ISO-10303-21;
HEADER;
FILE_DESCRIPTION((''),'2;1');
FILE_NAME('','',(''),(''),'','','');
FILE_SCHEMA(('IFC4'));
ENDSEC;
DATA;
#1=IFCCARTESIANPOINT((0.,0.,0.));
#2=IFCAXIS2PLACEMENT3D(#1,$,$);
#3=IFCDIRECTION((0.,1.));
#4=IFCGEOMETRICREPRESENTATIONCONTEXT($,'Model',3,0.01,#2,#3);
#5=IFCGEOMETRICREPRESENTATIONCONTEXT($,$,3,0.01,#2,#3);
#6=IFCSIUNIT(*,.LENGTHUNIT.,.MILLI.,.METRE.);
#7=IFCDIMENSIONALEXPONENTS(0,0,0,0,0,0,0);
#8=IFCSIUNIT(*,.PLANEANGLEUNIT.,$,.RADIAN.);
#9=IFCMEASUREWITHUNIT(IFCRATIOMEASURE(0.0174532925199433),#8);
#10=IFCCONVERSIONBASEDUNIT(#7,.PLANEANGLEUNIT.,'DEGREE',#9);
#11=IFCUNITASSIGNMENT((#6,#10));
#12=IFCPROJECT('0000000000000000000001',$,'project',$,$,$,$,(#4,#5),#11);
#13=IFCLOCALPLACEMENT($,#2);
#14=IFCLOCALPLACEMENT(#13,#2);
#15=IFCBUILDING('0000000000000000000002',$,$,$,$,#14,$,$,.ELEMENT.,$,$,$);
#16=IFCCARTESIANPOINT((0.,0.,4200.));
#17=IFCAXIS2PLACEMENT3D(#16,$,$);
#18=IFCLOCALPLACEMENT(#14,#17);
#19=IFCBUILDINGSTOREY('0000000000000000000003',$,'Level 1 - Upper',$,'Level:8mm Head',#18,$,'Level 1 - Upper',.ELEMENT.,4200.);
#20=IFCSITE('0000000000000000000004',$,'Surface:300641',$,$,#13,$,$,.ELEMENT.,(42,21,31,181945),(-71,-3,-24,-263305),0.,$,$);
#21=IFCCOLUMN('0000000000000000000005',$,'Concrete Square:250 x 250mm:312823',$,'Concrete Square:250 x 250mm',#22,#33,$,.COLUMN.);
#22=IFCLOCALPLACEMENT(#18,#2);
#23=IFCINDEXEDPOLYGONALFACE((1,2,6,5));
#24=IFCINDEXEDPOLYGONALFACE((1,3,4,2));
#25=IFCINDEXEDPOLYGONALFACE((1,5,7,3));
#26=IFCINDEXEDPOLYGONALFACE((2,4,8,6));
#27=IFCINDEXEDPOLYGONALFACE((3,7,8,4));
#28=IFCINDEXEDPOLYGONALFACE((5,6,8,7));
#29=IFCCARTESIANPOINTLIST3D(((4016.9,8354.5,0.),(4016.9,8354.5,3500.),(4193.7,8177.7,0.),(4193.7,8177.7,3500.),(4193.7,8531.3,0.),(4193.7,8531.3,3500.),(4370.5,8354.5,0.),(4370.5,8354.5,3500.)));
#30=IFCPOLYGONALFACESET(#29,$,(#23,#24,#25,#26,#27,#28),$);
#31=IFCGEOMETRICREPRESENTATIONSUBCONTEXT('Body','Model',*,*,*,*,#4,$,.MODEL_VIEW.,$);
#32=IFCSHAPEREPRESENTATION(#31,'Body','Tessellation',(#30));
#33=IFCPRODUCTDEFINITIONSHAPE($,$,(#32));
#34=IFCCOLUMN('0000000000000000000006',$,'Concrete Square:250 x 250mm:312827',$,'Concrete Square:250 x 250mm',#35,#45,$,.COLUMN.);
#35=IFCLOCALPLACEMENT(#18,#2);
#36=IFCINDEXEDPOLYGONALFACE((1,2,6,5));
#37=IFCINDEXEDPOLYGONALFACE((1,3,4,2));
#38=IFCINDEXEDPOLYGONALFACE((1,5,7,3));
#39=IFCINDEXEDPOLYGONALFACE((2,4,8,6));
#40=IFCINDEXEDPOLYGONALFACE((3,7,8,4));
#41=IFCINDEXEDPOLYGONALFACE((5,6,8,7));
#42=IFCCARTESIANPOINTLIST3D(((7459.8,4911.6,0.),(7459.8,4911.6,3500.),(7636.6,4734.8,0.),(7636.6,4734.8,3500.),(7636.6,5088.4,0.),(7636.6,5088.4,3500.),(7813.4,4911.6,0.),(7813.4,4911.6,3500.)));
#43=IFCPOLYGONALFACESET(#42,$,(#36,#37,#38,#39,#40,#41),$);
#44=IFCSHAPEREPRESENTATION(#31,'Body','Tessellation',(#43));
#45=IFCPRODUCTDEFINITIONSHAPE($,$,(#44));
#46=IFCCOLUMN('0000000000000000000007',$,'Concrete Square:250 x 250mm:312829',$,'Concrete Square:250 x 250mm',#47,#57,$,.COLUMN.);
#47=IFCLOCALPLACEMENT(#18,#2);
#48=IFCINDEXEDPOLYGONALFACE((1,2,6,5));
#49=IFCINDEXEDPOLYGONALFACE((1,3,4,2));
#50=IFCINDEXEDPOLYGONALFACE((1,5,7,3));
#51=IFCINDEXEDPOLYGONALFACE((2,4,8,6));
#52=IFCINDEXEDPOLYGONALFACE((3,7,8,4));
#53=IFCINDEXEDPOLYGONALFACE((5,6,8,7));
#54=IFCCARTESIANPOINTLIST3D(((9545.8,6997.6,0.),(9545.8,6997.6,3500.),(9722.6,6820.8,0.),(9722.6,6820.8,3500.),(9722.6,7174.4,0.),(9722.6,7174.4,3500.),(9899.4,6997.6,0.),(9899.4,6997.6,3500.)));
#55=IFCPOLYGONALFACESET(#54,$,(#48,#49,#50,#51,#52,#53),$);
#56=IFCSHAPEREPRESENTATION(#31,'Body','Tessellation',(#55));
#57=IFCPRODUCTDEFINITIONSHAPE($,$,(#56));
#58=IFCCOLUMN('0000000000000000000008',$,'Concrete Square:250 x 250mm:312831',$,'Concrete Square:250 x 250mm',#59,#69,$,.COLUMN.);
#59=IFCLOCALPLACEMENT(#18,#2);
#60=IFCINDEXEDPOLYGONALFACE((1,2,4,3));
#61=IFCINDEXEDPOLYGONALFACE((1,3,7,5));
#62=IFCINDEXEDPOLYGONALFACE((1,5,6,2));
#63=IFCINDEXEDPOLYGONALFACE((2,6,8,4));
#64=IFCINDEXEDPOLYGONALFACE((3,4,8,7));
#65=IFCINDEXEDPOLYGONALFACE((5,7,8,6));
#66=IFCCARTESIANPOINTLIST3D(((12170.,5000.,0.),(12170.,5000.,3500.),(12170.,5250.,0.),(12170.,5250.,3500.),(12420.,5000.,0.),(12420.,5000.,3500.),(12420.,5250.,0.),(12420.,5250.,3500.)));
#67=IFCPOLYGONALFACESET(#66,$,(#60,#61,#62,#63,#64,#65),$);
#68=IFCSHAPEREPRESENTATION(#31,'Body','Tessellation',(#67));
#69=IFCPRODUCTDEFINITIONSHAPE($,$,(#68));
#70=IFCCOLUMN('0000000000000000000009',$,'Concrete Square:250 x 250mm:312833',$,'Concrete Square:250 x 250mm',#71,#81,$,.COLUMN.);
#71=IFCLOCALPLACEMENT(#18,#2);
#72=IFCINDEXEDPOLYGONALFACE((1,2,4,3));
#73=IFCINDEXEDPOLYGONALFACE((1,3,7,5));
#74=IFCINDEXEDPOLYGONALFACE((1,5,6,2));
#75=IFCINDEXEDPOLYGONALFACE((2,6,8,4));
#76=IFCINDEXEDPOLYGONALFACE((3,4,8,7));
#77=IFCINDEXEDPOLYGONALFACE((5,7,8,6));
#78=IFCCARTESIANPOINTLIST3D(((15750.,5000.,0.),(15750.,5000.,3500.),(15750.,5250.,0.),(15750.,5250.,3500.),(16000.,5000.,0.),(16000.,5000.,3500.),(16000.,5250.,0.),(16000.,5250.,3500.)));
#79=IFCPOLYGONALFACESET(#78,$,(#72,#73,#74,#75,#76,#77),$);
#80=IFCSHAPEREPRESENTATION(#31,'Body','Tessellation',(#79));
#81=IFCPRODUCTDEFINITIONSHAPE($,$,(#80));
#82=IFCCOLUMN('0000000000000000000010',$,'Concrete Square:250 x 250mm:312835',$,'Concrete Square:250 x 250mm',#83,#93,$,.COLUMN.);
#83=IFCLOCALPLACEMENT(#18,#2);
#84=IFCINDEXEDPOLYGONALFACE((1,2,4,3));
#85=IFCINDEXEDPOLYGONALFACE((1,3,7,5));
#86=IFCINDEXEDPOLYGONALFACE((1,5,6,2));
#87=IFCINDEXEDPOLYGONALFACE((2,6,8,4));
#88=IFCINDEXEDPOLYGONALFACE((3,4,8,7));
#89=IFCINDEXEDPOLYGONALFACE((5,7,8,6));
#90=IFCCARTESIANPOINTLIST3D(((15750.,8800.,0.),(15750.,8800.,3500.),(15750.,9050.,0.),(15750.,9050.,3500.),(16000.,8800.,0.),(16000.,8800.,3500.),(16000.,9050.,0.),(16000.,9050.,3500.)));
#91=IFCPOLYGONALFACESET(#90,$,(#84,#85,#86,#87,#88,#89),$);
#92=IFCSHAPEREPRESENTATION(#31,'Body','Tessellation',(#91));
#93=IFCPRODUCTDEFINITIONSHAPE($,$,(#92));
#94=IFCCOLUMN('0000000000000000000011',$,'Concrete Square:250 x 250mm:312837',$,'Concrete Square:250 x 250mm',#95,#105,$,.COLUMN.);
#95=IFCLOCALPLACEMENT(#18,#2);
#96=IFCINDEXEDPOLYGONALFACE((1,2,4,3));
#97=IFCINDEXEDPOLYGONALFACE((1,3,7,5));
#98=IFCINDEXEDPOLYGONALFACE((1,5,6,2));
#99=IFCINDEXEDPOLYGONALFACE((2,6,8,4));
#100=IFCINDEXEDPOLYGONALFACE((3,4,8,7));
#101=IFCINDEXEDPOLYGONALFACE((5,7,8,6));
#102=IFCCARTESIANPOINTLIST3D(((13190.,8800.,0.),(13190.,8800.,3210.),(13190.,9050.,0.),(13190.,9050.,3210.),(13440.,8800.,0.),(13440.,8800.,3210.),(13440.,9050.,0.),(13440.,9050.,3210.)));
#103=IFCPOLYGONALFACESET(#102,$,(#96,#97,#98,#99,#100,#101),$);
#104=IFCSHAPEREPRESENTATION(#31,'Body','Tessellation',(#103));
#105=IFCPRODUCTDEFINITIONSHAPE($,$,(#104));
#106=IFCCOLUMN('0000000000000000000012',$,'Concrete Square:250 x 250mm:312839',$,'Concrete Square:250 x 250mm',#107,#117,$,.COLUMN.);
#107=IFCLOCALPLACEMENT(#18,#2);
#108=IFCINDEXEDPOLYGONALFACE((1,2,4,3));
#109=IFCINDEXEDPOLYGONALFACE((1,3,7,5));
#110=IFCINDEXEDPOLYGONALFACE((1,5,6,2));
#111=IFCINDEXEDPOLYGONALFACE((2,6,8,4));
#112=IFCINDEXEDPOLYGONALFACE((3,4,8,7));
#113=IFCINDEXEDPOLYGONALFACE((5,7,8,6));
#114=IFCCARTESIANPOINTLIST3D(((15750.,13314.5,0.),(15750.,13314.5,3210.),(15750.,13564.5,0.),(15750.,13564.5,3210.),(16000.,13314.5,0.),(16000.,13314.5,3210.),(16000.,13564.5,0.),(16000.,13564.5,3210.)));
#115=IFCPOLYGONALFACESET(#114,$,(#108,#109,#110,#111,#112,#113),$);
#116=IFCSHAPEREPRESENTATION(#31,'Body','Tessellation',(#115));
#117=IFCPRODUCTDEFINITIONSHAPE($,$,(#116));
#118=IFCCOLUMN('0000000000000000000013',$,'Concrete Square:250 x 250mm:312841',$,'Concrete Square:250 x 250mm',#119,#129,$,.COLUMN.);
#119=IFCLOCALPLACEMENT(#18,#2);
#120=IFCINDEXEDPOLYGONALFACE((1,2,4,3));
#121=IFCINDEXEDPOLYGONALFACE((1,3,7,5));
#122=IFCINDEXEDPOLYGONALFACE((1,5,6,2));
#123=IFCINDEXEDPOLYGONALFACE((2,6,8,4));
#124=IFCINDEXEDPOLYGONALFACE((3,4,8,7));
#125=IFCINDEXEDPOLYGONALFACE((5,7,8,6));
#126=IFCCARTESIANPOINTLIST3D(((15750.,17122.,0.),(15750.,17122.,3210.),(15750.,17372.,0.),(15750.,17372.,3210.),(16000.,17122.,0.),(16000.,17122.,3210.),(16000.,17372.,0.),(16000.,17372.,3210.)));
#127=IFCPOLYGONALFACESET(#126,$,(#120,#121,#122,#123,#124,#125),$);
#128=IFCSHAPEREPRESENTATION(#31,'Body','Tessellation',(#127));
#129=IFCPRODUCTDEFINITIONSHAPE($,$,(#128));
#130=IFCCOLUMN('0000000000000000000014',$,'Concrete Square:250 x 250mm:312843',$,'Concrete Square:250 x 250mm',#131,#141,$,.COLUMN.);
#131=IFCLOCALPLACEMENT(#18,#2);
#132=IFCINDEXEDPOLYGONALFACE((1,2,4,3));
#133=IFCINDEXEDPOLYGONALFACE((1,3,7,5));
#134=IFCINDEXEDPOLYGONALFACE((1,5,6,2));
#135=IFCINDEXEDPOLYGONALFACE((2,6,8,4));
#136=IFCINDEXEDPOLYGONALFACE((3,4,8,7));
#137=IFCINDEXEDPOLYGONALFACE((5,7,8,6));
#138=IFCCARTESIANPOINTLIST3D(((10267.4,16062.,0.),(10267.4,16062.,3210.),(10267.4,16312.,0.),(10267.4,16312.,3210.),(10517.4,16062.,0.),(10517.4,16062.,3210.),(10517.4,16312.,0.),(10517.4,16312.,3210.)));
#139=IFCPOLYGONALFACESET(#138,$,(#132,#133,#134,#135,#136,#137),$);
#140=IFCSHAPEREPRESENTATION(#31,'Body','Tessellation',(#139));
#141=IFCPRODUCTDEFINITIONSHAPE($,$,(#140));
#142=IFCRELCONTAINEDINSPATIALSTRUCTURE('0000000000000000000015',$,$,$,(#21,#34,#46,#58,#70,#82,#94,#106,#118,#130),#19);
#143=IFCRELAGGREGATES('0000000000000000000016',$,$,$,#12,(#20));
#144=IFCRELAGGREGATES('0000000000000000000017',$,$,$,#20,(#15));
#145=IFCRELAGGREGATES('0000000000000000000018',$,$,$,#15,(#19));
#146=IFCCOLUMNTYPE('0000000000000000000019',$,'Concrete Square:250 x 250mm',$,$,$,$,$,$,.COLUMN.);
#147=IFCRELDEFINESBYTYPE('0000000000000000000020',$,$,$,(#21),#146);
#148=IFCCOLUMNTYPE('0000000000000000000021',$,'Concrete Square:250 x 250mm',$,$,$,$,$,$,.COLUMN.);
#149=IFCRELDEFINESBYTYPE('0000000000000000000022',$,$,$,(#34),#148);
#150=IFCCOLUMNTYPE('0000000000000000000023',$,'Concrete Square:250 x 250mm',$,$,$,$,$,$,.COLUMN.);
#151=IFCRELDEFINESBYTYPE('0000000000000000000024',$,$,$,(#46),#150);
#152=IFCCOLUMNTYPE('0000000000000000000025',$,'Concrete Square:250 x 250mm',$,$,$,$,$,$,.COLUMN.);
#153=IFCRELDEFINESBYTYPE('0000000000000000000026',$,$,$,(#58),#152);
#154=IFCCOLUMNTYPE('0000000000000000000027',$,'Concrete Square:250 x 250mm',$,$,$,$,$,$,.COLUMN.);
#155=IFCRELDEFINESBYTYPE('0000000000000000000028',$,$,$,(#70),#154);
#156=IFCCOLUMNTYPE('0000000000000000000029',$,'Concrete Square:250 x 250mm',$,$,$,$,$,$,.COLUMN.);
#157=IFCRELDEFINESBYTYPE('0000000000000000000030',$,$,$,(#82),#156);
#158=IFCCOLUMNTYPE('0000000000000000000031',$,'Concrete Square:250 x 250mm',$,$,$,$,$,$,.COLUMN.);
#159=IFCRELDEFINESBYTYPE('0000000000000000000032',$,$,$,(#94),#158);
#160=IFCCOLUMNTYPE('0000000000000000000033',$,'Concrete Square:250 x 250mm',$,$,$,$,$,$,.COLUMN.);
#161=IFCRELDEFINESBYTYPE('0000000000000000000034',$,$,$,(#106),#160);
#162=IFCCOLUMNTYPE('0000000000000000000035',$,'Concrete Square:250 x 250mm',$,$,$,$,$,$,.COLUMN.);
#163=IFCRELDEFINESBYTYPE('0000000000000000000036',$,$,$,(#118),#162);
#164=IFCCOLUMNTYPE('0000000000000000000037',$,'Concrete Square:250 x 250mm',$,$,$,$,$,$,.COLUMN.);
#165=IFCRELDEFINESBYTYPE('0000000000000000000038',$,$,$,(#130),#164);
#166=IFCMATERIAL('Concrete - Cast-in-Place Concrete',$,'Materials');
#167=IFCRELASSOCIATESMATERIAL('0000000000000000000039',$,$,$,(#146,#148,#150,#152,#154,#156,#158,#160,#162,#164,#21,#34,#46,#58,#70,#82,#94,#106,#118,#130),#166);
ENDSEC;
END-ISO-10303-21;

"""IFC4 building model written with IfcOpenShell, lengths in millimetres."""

from ifc_helpers import new_model, entity, si_unit, converted_unit, direction, frame, frame_2d, origin, origin_2d_with_axis, place, context, subcontext, project, spatial, rectangle, extrude, source, transform, mapped, material, material_profile, profile_set, profile_usage, type_object, type_shapes, element, save


model = new_model("IFC4")

# Units and contexts
model_context = context("Model", 3, precision=0.01, world=origin(), true_north=direction((0.0, 1.0)))
context_of_model = context(None, 3, precision=0.01, world=origin(), true_north=direction((0.0, 1.0)))
body_context = subcontext(model_context, "Body", "Model", "MODEL_VIEW")
ifc_project = project(units=[si_unit("LENGTHUNIT", "METRE", prefix="MILLI"), converted_unit("PLANEANGLEUNIT", "DEGREE", entity("IfcRatioMeasure", 0.0174532925199433), si_unit("PLANEANGLEUNIT", "RADIAN"), dimensions=[0, 0, 0, 0, 0, 0, 0])], contexts=[model_context, context_of_model])

# Site, building, storey
site_placement = place(None, origin())
site = spatial("IfcSite", under=ifc_project, at=site_placement, Name="Surface:300641", CompositionType="ELEMENT", RefLatitude=(42, 21, 31, 181945), RefLongitude=(-71, -3, -24, -263305), RefElevation=0.0)
building_placement = place(site_placement, origin())
building = spatial("IfcBuilding", under=site, at=building_placement, CompositionType="ELEMENT")
storey_placement = place(building_placement, frame((0.0, 0.0, 4200.0)))
storey = spatial("IfcBuildingStorey", under=building, at=storey_placement, Name="Level 1 - Upper", ObjectType="Level:8mm Head", LongName="Level 1 - Upper", CompositionType="ELEMENT", Elevation=4200.0)

# Columns
ifc_material = material(Name="Concrete - Cast-in-Place Concrete", Category="Materials")
ifc_material_profile_1 = material_profile(ifc_material, rectangle(XDim=250.0, YDim=250.0, at=frame_2d((0.0, 0.0), x_axis=(1.0, 0.0))), Name="250 x 250mm")
ifc_profile_set_1 = profile_set([ifc_material_profile_1], Name="250 x 250mm")
ifc_profile_usage_1 = profile_usage(ifc_profile_set_1)
column_type_1 = type_object("IfcColumnType", Name="Concrete Square:250 x 250mm", PredefinedType="COLUMN", material=ifc_profile_set_1)
shared_shape_1 = source(origin(), body_context, "Body", "SweptSolid", [
    extrude(rectangle(XDim=250.0, YDim=250.0, at=frame_2d((0.0, 0.0), x_axis=(1.0, 0.0))), frame((4193.7, 8354.5, 4200.0), z_axis=(0.0, 0.0, 1.0), x_axis=(-0.707107, 0.707107, 0.0)), (0.0, 0.0, 1.0), 3500.0),
])
type_shapes(column_type_1, [shared_shape_1])
column_1_placement = place(storey_placement, frame((0.0, 0.0, -4200.0)))
element("IfcColumn", 1, at=column_1_placement, inside=storey, type_object=column_type_1, material=ifc_profile_usage_1, Name="Concrete Square:250 x 250mm:312823", ObjectType="Concrete Square:250 x 250mm", PredefinedType="COLUMN", context=body_context, shape_type="MappedRepresentation", body=[
    mapped(shared_shape_1, transform((0.0, 0.0, 0.0), scale=1.0)),
])
ifc_profile_usage_2 = profile_usage(ifc_profile_set_1)
column_type_2 = type_object("IfcColumnType", Name="Concrete Square:250 x 250mm", PredefinedType="COLUMN", material=ifc_profile_set_1)
shared_shape_2 = source(origin(), body_context, "Body", "SweptSolid", [
    extrude(rectangle(XDim=250.0, YDim=250.0, at=frame_2d((0.0, 0.0), x_axis=(1.0, 0.0))), frame((7636.6, 4911.6, 4200.0), z_axis=(0.0, 0.0, 1.0), x_axis=(-0.707107, 0.707107, 0.0)), (0.0, 0.0, 1.0), 3500.0),
])
type_shapes(column_type_2, [shared_shape_2])
column_2_placement = place(storey_placement, frame((0.0, 0.0, -4200.0)))
element("IfcColumn", 2, at=column_2_placement, inside=storey, type_object=column_type_2, material=ifc_profile_usage_2, Name="Concrete Square:250 x 250mm:312827", ObjectType="Concrete Square:250 x 250mm", PredefinedType="COLUMN", context=body_context, shape_type="MappedRepresentation", body=[
    mapped(shared_shape_2, transform((0.0, 0.0, 0.0), scale=1.0)),
])
ifc_profile_usage_3 = profile_usage(ifc_profile_set_1)
column_type_3 = type_object("IfcColumnType", Name="Concrete Square:250 x 250mm", PredefinedType="COLUMN", material=ifc_profile_set_1)
shared_shape_3 = source(origin(), body_context, "Body", "SweptSolid", [
    extrude(rectangle(XDim=250.0, YDim=250.0, at=frame_2d((0.0, 0.0), x_axis=(1.0, 0.0))), frame((9722.6, 6997.6, 4200.0), z_axis=(0.0, 0.0, 1.0), x_axis=(-0.707107, 0.707107, 0.0)), (0.0, 0.0, 1.0), 3500.0),
])
type_shapes(column_type_3, [shared_shape_3])
column_3_placement = place(storey_placement, frame((0.0, 0.0, -4200.0)))
element("IfcColumn", 3, at=column_3_placement, inside=storey, type_object=column_type_3, material=ifc_profile_usage_3, Name="Concrete Square:250 x 250mm:312829", ObjectType="Concrete Square:250 x 250mm", PredefinedType="COLUMN", context=body_context, shape_type="MappedRepresentation", body=[
    mapped(shared_shape_3, transform((0.0, 0.0, 0.0), scale=1.0)),
])
ifc_profile_usage_4 = profile_usage(ifc_profile_set_1)
column_type_4 = type_object("IfcColumnType", Name="Concrete Square:250 x 250mm", PredefinedType="COLUMN", material=ifc_profile_set_1)
shared_shape_4 = source(origin(), body_context, "Body", "SweptSolid", [
    extrude(rectangle(XDim=250.0, YDim=250.0, at=origin_2d_with_axis()), frame((12295.0, 5125.0, 4200.0), z_axis=(0.0, 0.0, 1.0), x_axis=(0.0, -1.0, 0.0)), (0.0, 0.0, 1.0), 3500.0),
])
type_shapes(column_type_4, [shared_shape_4])
column_4_placement = place(storey_placement, frame((0.0, 0.0, -4200.0)))
element("IfcColumn", 4, at=column_4_placement, inside=storey, type_object=column_type_4, material=ifc_profile_usage_4, Name="Concrete Square:250 x 250mm:312831", ObjectType="Concrete Square:250 x 250mm", PredefinedType="COLUMN", context=body_context, shape_type="MappedRepresentation", body=[
    mapped(shared_shape_4, transform((0.0, 0.0, 0.0), scale=1.0)),
])
ifc_profile_usage_5 = profile_usage(ifc_profile_set_1)
column_type_5 = type_object("IfcColumnType", Name="Concrete Square:250 x 250mm", PredefinedType="COLUMN", material=ifc_profile_set_1)
shared_shape_5 = source(origin(), body_context, "Body", "SweptSolid", [
    extrude(rectangle(XDim=250.0, YDim=250.0, at=origin_2d_with_axis()), frame((15875.0, 5125.0, 4200.0), z_axis=(0.0, 0.0, 1.0), x_axis=(0.0, -1.0, 0.0)), (0.0, 0.0, 1.0), 3500.0),
])
type_shapes(column_type_5, [shared_shape_5])
column_5_placement = place(storey_placement, frame((0.0, 0.0, -4200.0)))
element("IfcColumn", 5, at=column_5_placement, inside=storey, type_object=column_type_5, material=ifc_profile_usage_5, Name="Concrete Square:250 x 250mm:312833", ObjectType="Concrete Square:250 x 250mm", PredefinedType="COLUMN", context=body_context, shape_type="MappedRepresentation", body=[
    mapped(shared_shape_5, transform((0.0, 0.0, 0.0), scale=1.0)),
])
ifc_profile_usage_6 = profile_usage(ifc_profile_set_1)
column_type_6 = type_object("IfcColumnType", Name="Concrete Square:250 x 250mm", PredefinedType="COLUMN", material=ifc_profile_set_1)
shared_shape_6 = source(origin(), body_context, "Body", "SweptSolid", [
    extrude(rectangle(XDim=250.0, YDim=250.0, at=origin_2d_with_axis()), frame((15875.0, 8925.0, 4200.0)), (0.0, 0.0, 1.0), 3500.0),
])
type_shapes(column_type_6, [shared_shape_6])
column_6_placement = place(storey_placement, frame((0.0, 0.0, -4200.0)))
element("IfcColumn", 6, at=column_6_placement, inside=storey, type_object=column_type_6, material=ifc_profile_usage_6, Name="Concrete Square:250 x 250mm:312835", ObjectType="Concrete Square:250 x 250mm", PredefinedType="COLUMN", context=body_context, shape_type="MappedRepresentation", body=[
    mapped(shared_shape_6, transform((0.0, 0.0, 0.0), scale=1.0)),
])
ifc_profile_usage_7 = profile_usage(ifc_profile_set_1)
column_type_7 = type_object("IfcColumnType", Name="Concrete Square:250 x 250mm", PredefinedType="COLUMN", material=ifc_profile_set_1)
shared_shape_7 = source(origin(), body_context, "Body", "SweptSolid", [
    extrude(rectangle(XDim=250.0, YDim=250.0, at=frame_2d((0.0, 0.0), x_axis=(1.0, 0.0))), frame((13315.0, 8925.0, 4200.0), z_axis=(0.0, 0.0, 1.0), x_axis=(0.0, -1.0, 0.0)), (0.0, 0.0, 1.0), 3210.0),
])
type_shapes(column_type_7, [shared_shape_7])
column_7_placement = place(storey_placement, frame((0.0, 0.0, -4200.0)))
element("IfcColumn", 7, at=column_7_placement, inside=storey, type_object=column_type_7, material=ifc_profile_usage_7, Name="Concrete Square:250 x 250mm:312837", ObjectType="Concrete Square:250 x 250mm", PredefinedType="COLUMN", context=body_context, shape_type="MappedRepresentation", body=[
    mapped(shared_shape_7, transform((0.0, 0.0, 0.0), scale=1.0)),
])
ifc_profile_usage_8 = profile_usage(ifc_profile_set_1)
column_type_8 = type_object("IfcColumnType", Name="Concrete Square:250 x 250mm", PredefinedType="COLUMN", material=ifc_profile_set_1)
shared_shape_8 = source(origin(), body_context, "Body", "SweptSolid", [
    extrude(rectangle(XDim=250.0, YDim=250.0, at=frame_2d((0.0, 0.0), x_axis=(1.0, 0.0))), frame((15875.0, 13439.5, 4200.0), z_axis=(0.0, 0.0, 1.0), x_axis=(0.0, -1.0, 0.0)), (0.0, 0.0, 1.0), 3210.0),
])
type_shapes(column_type_8, [shared_shape_8])
column_8_placement = place(storey_placement, frame((0.0, 0.0, -4200.0)))
element("IfcColumn", 8, at=column_8_placement, inside=storey, type_object=column_type_8, material=ifc_profile_usage_8, Name="Concrete Square:250 x 250mm:312839", ObjectType="Concrete Square:250 x 250mm", PredefinedType="COLUMN", context=body_context, shape_type="MappedRepresentation", body=[
    mapped(shared_shape_8, transform((0.0, 0.0, 0.0), scale=1.0)),
])
ifc_profile_usage_9 = profile_usage(ifc_profile_set_1)
column_type_9 = type_object("IfcColumnType", Name="Concrete Square:250 x 250mm", PredefinedType="COLUMN", material=ifc_profile_set_1)
shared_shape_9 = source(origin(), body_context, "Body", "SweptSolid", [
    extrude(rectangle(XDim=250.0, YDim=250.0, at=origin_2d_with_axis()), frame((15875.0, 17247.0, 4200.0), z_axis=(0.0, 0.0, 1.0), x_axis=(0.0, -1.0, 0.0)), (0.0, 0.0, 1.0), 3210.0),
])
type_shapes(column_type_9, [shared_shape_9])
column_9_placement = place(storey_placement, frame((0.0, 0.0, -4200.0)))
element("IfcColumn", 9, at=column_9_placement, inside=storey, type_object=column_type_9, material=ifc_profile_usage_9, Name="Concrete Square:250 x 250mm:312841", ObjectType="Concrete Square:250 x 250mm", PredefinedType="COLUMN", context=body_context, shape_type="MappedRepresentation", body=[
    mapped(shared_shape_9, transform((0.0, 0.0, 0.0), scale=1.0)),
])
ifc_profile_usage_10 = profile_usage(ifc_profile_set_1)
column_type_10 = type_object("IfcColumnType", Name="Concrete Square:250 x 250mm", PredefinedType="COLUMN", material=ifc_profile_set_1)
shared_shape_10 = source(origin(), body_context, "Body", "SweptSolid", [
    extrude(rectangle(XDim=250.0, YDim=250.0, at=frame_2d((0.0, 0.0), x_axis=(1.0, 0.0))), frame((10392.4, 16187.0, 4200.0), z_axis=(0.0, 0.0, 1.0), x_axis=(0.0, -1.0, 0.0)), (0.0, 0.0, 1.0), 3210.0),
])
type_shapes(column_type_10, [shared_shape_10])
column_10_placement = place(storey_placement, frame((0.0, 0.0, -4200.0)))
element("IfcColumn", 10, at=column_10_placement, inside=storey, type_object=column_type_10, material=ifc_profile_usage_10, Name="Concrete Square:250 x 250mm:312843", ObjectType="Concrete Square:250 x 250mm", PredefinedType="COLUMN", context=body_context, shape_type="MappedRepresentation", body=[
    mapped(shared_shape_10, transform((0.0, 0.0, 0.0), scale=1.0)),
])

save(model, "model.ifc")
